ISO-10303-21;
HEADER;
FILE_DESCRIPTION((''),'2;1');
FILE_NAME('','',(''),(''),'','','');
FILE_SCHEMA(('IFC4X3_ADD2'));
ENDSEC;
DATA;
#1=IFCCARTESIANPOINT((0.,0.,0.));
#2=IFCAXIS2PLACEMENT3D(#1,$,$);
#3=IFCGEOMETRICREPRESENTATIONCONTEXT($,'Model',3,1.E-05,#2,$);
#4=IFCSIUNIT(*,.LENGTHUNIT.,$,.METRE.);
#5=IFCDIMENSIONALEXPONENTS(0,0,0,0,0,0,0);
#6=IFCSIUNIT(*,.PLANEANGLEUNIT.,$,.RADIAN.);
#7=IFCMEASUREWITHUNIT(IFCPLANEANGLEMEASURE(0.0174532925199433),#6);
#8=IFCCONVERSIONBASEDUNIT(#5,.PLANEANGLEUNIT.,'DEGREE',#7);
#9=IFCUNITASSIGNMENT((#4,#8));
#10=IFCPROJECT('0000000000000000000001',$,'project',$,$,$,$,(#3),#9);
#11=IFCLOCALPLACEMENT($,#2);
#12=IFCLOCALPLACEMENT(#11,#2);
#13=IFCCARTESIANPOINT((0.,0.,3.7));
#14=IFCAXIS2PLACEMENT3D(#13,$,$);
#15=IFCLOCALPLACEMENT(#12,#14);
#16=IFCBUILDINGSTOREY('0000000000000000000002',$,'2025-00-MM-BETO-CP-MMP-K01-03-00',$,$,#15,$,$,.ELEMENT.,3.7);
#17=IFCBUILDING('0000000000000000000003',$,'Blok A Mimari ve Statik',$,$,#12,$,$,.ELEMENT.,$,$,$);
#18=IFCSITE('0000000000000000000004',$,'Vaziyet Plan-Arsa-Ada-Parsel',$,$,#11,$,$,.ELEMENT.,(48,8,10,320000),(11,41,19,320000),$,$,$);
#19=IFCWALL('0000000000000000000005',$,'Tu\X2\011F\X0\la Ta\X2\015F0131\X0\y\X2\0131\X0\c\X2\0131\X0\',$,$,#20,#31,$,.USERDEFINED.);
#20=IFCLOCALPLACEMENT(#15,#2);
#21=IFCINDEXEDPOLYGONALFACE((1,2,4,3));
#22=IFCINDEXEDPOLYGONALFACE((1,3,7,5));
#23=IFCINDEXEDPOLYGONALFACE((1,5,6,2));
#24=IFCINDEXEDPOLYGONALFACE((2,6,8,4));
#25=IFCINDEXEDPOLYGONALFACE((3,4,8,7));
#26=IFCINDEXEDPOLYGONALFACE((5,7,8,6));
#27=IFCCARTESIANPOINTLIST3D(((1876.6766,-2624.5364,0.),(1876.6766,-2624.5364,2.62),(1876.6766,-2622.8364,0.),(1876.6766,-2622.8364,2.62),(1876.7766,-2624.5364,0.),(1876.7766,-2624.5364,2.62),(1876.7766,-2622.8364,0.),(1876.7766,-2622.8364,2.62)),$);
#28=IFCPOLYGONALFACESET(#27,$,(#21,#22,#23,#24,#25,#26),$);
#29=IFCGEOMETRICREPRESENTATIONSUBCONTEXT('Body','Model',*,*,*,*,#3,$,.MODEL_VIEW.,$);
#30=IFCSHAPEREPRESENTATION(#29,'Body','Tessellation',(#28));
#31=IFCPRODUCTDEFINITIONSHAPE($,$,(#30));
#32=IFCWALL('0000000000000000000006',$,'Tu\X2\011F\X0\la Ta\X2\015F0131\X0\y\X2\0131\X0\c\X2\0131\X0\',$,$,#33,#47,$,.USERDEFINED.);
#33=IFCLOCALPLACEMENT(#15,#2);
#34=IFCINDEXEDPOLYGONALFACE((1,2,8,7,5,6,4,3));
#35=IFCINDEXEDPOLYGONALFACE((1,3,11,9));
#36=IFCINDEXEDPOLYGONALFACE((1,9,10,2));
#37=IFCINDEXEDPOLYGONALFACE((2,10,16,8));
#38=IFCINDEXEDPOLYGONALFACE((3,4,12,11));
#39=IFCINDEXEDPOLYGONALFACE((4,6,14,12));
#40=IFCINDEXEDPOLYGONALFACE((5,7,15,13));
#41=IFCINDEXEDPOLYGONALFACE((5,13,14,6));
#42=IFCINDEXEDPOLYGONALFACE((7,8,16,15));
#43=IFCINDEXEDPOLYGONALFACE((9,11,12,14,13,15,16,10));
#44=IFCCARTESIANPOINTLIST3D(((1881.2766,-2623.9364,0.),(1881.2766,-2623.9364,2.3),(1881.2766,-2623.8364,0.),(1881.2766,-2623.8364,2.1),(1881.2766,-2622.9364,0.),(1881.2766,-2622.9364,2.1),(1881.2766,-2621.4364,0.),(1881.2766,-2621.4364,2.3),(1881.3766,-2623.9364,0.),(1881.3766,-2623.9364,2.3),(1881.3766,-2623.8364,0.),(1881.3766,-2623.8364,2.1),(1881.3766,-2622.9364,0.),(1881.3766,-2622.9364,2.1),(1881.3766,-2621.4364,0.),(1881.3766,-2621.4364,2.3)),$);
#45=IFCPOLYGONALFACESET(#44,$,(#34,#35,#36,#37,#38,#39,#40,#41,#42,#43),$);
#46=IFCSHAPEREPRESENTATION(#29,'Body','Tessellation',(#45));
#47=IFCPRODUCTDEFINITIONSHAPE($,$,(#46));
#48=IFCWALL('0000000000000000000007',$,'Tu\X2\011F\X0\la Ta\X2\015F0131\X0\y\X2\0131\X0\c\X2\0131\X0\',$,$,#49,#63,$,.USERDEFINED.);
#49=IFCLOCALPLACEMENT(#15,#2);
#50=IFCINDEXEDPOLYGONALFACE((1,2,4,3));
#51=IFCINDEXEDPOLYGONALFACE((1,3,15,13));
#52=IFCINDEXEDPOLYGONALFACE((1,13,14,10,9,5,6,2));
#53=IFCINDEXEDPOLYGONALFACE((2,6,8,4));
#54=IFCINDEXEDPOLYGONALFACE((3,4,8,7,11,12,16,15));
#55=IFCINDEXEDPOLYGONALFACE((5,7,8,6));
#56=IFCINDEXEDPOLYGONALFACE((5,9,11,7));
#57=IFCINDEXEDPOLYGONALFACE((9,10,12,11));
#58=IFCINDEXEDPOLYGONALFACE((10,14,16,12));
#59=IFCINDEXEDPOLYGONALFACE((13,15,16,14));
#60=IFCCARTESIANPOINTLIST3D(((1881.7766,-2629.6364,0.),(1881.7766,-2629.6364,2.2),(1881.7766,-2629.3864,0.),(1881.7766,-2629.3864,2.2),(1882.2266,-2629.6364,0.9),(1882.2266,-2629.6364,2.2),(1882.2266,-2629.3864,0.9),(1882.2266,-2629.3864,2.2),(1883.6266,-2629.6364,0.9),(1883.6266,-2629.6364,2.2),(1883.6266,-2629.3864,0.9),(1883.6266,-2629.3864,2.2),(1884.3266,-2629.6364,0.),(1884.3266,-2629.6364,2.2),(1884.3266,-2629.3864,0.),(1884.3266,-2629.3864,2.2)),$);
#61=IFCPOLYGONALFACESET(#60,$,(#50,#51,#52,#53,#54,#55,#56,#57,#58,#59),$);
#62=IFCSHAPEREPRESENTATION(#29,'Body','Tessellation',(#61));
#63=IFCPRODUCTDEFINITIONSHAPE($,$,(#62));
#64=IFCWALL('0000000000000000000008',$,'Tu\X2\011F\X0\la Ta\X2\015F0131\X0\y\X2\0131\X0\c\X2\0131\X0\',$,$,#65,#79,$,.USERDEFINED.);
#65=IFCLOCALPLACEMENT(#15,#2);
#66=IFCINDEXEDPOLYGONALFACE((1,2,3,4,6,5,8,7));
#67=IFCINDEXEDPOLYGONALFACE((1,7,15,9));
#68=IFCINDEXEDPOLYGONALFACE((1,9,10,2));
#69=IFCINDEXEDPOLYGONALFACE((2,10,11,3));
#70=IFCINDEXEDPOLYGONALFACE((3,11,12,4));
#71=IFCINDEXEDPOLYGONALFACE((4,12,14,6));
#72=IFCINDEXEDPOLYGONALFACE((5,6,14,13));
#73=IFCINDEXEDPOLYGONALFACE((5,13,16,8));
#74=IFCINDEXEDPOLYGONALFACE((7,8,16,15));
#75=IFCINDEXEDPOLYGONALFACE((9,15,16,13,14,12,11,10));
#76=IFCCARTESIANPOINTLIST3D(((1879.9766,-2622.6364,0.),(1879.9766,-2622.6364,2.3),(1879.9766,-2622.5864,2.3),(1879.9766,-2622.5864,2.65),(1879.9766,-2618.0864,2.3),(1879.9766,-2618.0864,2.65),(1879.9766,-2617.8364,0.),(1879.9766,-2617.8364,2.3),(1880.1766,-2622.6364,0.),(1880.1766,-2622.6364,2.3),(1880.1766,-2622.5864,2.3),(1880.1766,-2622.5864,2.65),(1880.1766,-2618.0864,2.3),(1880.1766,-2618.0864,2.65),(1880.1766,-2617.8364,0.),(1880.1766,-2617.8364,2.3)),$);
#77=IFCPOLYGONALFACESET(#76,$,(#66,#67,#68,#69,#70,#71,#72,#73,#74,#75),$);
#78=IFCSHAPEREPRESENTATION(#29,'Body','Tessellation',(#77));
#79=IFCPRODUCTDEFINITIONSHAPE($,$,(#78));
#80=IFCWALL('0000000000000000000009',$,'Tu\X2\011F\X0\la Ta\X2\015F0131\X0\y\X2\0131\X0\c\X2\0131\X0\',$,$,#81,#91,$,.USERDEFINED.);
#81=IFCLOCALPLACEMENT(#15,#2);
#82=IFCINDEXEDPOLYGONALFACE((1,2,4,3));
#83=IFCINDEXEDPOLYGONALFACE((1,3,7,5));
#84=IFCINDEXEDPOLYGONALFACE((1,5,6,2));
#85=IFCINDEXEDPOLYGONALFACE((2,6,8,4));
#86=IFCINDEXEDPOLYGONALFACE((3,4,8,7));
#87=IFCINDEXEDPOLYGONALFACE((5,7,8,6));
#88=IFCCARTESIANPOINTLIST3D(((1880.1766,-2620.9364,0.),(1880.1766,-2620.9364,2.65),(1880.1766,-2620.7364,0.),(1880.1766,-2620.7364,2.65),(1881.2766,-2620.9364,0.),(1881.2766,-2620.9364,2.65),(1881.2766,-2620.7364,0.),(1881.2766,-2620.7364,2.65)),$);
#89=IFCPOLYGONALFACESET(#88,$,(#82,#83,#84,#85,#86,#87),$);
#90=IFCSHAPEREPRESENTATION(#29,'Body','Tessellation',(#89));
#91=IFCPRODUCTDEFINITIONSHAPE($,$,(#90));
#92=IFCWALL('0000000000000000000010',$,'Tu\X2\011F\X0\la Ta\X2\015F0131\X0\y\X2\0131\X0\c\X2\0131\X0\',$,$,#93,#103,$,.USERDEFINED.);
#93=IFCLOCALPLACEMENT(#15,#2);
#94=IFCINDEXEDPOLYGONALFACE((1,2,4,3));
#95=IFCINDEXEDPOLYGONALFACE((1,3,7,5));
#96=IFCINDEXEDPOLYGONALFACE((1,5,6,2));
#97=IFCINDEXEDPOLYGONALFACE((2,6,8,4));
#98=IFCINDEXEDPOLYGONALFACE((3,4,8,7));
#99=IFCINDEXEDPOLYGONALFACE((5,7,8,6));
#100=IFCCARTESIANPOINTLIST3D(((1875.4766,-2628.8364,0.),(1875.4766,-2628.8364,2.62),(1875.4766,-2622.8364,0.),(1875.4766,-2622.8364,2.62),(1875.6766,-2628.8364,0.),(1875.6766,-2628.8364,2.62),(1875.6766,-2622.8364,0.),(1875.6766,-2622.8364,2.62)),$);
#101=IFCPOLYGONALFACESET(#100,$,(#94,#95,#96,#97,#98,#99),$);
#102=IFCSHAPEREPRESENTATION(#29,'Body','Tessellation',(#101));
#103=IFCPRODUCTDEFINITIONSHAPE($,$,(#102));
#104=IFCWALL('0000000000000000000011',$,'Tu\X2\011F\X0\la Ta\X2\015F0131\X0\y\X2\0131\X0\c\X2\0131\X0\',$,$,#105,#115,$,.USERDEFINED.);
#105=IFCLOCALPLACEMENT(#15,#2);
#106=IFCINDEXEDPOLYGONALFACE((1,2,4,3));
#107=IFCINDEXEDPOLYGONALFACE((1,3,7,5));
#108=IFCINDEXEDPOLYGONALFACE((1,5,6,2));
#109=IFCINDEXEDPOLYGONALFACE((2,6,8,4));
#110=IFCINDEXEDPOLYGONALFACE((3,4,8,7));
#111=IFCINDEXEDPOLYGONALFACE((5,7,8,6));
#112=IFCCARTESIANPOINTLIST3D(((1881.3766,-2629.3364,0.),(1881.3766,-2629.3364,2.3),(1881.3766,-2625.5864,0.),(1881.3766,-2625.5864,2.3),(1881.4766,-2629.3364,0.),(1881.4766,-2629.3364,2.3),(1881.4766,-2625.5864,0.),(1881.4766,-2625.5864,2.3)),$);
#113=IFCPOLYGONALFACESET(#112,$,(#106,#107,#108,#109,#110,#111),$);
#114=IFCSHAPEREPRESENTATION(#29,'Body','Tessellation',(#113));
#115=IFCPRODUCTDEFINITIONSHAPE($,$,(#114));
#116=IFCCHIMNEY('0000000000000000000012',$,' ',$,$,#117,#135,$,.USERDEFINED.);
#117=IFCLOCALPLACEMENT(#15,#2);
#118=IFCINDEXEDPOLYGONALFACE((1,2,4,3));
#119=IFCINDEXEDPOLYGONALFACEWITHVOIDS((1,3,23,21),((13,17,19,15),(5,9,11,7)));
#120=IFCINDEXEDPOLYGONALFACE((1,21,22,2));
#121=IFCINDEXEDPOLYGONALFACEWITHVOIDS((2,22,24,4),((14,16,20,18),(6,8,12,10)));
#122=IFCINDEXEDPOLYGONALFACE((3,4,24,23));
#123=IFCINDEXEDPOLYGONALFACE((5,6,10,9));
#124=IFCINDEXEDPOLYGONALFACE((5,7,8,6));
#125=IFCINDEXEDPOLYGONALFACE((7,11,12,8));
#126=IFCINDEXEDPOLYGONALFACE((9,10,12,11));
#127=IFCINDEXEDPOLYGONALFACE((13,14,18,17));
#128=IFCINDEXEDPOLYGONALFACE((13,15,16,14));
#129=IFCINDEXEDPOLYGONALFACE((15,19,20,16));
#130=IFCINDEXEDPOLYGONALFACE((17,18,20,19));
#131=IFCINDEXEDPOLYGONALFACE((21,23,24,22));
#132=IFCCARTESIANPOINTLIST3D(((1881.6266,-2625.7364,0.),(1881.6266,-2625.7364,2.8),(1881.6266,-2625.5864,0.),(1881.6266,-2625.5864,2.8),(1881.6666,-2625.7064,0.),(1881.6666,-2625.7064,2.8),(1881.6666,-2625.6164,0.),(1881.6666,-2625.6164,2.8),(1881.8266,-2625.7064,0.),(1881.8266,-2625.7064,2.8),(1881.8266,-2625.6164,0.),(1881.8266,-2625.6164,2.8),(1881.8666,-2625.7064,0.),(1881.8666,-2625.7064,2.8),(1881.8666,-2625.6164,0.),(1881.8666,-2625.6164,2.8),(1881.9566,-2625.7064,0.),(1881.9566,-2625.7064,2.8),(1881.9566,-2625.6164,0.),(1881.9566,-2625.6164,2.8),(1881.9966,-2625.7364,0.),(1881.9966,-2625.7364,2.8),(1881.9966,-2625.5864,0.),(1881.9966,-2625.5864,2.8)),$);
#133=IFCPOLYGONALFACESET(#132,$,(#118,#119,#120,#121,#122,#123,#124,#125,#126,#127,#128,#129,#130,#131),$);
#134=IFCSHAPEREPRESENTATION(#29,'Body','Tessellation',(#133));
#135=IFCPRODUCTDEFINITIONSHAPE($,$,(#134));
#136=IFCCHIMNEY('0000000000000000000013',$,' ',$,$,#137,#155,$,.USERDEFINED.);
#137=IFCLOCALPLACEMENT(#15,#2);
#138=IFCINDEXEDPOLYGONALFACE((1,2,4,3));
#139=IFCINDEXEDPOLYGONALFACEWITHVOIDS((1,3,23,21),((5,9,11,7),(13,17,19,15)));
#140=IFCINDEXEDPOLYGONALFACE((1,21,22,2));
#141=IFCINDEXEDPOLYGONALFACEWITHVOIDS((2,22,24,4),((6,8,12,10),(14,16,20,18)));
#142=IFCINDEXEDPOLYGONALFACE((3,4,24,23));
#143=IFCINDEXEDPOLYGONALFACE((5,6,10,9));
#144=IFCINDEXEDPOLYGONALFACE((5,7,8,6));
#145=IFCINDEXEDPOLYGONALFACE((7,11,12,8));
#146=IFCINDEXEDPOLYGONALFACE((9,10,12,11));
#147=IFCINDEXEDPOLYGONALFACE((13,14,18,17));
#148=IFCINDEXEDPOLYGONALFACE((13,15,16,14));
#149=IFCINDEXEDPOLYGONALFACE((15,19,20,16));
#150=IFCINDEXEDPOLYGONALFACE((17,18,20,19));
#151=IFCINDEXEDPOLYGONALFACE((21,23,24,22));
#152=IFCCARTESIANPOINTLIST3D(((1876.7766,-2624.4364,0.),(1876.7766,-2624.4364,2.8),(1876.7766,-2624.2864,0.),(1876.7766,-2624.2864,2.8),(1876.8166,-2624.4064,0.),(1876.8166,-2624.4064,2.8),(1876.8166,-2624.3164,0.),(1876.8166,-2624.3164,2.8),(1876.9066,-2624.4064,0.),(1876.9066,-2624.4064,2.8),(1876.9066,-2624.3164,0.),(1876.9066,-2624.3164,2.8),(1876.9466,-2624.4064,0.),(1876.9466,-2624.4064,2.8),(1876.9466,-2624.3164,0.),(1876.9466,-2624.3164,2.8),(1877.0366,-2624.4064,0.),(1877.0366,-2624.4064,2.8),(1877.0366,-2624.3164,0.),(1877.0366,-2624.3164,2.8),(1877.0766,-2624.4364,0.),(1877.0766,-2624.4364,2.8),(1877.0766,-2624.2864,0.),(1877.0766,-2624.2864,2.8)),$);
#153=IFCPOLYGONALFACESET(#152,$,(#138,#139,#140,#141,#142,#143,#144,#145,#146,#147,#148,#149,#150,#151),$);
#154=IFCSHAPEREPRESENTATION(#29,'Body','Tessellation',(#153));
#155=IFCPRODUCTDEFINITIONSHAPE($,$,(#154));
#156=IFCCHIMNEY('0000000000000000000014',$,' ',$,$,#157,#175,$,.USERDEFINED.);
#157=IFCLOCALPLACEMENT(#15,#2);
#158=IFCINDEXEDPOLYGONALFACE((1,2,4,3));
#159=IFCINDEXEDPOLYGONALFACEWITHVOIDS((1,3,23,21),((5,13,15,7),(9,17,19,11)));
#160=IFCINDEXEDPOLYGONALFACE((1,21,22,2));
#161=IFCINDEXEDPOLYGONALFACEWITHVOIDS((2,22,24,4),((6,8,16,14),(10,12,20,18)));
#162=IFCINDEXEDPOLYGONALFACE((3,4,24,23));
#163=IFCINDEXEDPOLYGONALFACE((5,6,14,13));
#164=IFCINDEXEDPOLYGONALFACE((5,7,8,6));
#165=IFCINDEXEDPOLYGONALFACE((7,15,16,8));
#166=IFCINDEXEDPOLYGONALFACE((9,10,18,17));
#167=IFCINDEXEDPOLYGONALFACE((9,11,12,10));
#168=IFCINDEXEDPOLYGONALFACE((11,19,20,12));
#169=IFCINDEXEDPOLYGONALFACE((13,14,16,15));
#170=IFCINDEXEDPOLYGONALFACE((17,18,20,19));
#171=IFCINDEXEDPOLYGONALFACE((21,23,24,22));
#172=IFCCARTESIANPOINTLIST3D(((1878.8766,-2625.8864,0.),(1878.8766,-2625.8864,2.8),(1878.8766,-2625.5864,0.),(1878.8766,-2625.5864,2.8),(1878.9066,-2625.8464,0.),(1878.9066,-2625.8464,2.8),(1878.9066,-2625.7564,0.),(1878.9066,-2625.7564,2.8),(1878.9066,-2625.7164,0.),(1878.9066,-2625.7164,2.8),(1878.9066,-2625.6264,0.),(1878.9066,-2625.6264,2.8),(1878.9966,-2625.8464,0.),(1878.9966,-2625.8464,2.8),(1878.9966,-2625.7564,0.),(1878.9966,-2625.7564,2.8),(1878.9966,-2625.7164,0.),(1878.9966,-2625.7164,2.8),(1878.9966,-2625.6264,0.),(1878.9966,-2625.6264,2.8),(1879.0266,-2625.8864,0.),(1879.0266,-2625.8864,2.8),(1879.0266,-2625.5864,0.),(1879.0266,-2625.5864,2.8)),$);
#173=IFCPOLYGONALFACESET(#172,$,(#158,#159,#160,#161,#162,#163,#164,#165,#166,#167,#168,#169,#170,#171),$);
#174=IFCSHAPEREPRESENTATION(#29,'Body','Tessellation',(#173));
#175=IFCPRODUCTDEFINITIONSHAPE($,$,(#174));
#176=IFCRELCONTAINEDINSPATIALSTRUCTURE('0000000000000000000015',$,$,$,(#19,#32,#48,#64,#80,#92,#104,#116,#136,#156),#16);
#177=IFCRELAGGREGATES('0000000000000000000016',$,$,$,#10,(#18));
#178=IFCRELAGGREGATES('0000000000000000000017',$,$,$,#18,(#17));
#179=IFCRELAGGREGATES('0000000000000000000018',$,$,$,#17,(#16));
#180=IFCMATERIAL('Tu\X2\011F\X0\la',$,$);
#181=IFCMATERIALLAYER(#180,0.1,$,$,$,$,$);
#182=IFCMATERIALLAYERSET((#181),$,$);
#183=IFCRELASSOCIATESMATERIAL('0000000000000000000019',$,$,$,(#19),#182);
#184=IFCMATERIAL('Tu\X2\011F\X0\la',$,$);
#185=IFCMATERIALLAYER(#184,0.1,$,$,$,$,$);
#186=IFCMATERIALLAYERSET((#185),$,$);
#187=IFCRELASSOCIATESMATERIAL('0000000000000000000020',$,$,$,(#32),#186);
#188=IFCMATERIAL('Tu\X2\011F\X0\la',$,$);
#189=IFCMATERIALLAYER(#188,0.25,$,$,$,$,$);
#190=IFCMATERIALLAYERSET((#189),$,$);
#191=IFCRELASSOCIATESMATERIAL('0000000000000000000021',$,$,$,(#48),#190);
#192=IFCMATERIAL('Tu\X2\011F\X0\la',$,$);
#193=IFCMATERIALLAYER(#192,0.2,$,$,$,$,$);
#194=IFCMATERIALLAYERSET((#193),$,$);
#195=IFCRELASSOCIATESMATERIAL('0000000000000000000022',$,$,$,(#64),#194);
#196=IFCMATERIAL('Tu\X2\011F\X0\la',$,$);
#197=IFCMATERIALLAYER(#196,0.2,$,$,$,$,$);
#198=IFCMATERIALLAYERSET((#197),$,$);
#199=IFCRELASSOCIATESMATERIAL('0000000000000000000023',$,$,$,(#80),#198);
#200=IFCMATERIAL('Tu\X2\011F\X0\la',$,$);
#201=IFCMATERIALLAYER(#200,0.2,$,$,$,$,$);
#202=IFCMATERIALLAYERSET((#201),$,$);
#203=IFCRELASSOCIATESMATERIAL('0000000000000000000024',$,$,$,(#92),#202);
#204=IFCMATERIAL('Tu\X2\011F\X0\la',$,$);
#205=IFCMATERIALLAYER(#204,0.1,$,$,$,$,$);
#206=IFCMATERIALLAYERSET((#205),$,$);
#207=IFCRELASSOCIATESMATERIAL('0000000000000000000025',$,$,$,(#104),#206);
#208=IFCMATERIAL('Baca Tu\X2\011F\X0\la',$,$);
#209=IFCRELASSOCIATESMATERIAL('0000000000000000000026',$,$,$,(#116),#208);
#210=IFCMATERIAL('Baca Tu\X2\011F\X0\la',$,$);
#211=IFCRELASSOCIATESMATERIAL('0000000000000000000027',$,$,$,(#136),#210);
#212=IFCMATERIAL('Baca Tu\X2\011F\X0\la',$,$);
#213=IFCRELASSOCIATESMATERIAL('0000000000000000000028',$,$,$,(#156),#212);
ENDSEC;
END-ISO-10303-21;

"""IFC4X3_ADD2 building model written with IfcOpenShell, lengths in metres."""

from ifc_helpers import new_model, entity, si_unit, converted_unit, frame, frame_2d, origin, origin_with_axes, place, context, subcontext, project, spatial, polyline, rectangle, outline, extrude, clip, bounded_halfspace, material, layer, layer_set, layer_usage, element, save


model = new_model("IFC4X3_ADD2")

# Units and contexts
model_context = context("Model", 3, precision=1e-05, world=origin())
body_context = subcontext(model_context, "Body", "Model", "MODEL_VIEW")
ifc_project = project(units=[si_unit("LENGTHUNIT", "METRE"), converted_unit("PLANEANGLEUNIT", "DEGREE", entity("IfcPlaneAngleMeasure", 0.0174532925199433), si_unit("PLANEANGLEUNIT", "RADIAN"), dimensions=[0, 0, 0, 0, 0, 0, 0])], contexts=[model_context])

# Site, building, storey
site_placement = place(None, origin())
site = spatial("IfcSite", under=ifc_project, at=site_placement, Name="Vaziyet Plan-Arsa-Ada-Parsel", CompositionType="ELEMENT", RefLatitude=(48, 8, 10, 320000), RefLongitude=(11, 41, 19, 320000))
building_placement = place(site_placement, origin())
building = spatial("IfcBuilding", under=site, at=building_placement, Name="Blok A Mimari ve Statik", CompositionType="ELEMENT")
storey_placement = place(building_placement, frame((0.0, 0.0, 3.7)))
storey = spatial("IfcBuildingStorey", under=building, at=storey_placement, Name="2025-00-MM-BETO-CP-MMP-K01-03-00", CompositionType="ELEMENT", Elevation=3.7)

# Wall
ifc_material_1 = material(Name="Tuğla")
ifc_layer_1 = layer(ifc_material_1, 0.1)
ifc_layer_set_1 = layer_set([ifc_layer_1])
ifc_layer_usage_1 = layer_usage(ifc_layer_set_1, "AXIS2", "POSITIVE", 0.0)
wall_1_placement = place(storey_placement, frame((1876.6766, -2622.8364, 0.0), z_axis=(0.0, 0.0, 1.0), x_axis=(0.0, -1.0, 0.0)))
element("IfcWall", 1, at=wall_1_placement, inside=storey, material=ifc_layer_usage_1, Name="Tuğla Taşıyıcı", PredefinedType="USERDEFINED", context=body_context, shape_type="SweptSolid", body=[
    extrude(rectangle(XDim=1.7, YDim=0.1, at=frame_2d((0.85, 0.05), x_axis=(1.0, 0.0))), origin_with_axes(), (0.0, 0.0, 1.0), 2.62),
])

# Walls, openings
ifc_material_2 = material(Name="Tuğla")
ifc_layer_2 = layer(ifc_material_2, 0.1)
ifc_layer_set_2 = layer_set([ifc_layer_2])
ifc_layer_usage_2 = layer_usage(ifc_layer_set_2, "AXIS2", "POSITIVE", 0.0)
wall_2_placement = place(storey_placement, frame((1881.2766, -2621.4364, 0.0), z_axis=(0.0, 0.0, 1.0), x_axis=(0.0, -1.0, 0.0)))
wall_2 = element("IfcWall", 2, at=wall_2_placement, inside=storey, material=ifc_layer_usage_2, Name="Tuğla Taşıyıcı", PredefinedType="USERDEFINED", context=body_context, shape_type="SweptSolid", body=[
    extrude(rectangle(XDim=2.5, YDim=0.1, at=frame_2d((1.25, 0.05), x_axis=(1.0, 0.0))), origin_with_axes(), (0.0, 0.0, 1.0), 2.3),
])
opening_1_placement = place(wall_2_placement, frame((2.4, 0.1, 0.0), z_axis=(0.0, -1.0, 0.0), x_axis=(0.0, 0.0, 1.0)))
element("IfcOpeningElement", 3, at=opening_1_placement, cuts=wall_2, PredefinedType="OPENING", context=body_context, shape_type="SweptSolid", body=[
    extrude(outline(polyline([(2.1, 0.9), (2.1, 0.0), (0.0, 0.0), (0.0, 0.9), (2.1, 0.9)])), origin_with_axes(), (0.0, 0.0, 1.0), 0.1),
])
ifc_material_3 = material(Name="Tuğla")
ifc_layer_3 = layer(ifc_material_3, 0.25)
ifc_layer_set_3 = layer_set([ifc_layer_3])
ifc_layer_usage_3 = layer_usage(ifc_layer_set_3, "AXIS2", "POSITIVE", 0.0)
wall_3_placement = place(storey_placement, frame((1881.7766, -2629.6364, 0.0), z_axis=(0.0, 0.0, 1.0), x_axis=(1.0, 0.0, 0.0)))
wall_3 = element("IfcWall", 4, at=wall_3_placement, inside=storey, material=ifc_layer_usage_3, Name="Tuğla Taşıyıcı", PredefinedType="USERDEFINED", context=body_context, shape_type="SweptSolid", body=[
    extrude(rectangle(XDim=2.55, YDim=0.25, at=frame_2d((1.275, 0.125), x_axis=(1.0, 0.0))), origin_with_axes(), (0.0, 0.0, 1.0), 2.2),
])
opening_2_placement = place(wall_3_placement, frame((0.45, 0.0, 0.9), z_axis=(0.0, 1.0, 0.0), x_axis=(0.0, 0.0, 1.0)))
element("IfcOpeningElement", 5, at=opening_2_placement, cuts=wall_3, PredefinedType="OPENING", context=body_context, shape_type="SweptSolid", body=[
    extrude(outline(polyline([(1.35, 1.4), (1.35, 0.0), (0.0, 0.0), (0.0, 1.4), (1.35, 1.4)])), origin_with_axes(), (0.0, 0.0, 1.0), 0.25),
])

# Walls
ifc_material_4 = material(Name="Tuğla")
ifc_layer_4 = layer(ifc_material_4, 0.2)
ifc_layer_set_4 = layer_set([ifc_layer_4])
ifc_layer_usage_4 = layer_usage(ifc_layer_set_4, "AXIS2", "POSITIVE", 0.0)
wall_4_placement = place(storey_placement, frame((1880.1766, -2622.6364, 0.0), z_axis=(0.0, 0.0, 1.0), x_axis=(0.0, 1.0, 0.0)))
element("IfcWall", 6, at=wall_4_placement, inside=storey, material=ifc_layer_usage_4, Name="Tuğla Taşıyıcı", PredefinedType="USERDEFINED", context=body_context, shape_type="Clipping", body=[
    clip(clip(extrude(rectangle(XDim=4.8, YDim=0.2, at=frame_2d((2.4, 0.1), x_axis=(1.0, 0.0))), origin_with_axes(), (0.0, 0.0, 1.0), 2.65), bounded_halfspace(frame((4.675, 0.1, 2.3), z_axis=(0.0, 0.0, -1.0), x_axis=(-1.0, 0.0, 0.0)), True, origin_with_axes(), polyline([(4.8, 0.2), (4.55, 0.2), (4.55, 0.0), (4.8, 0.0), (4.8, 0.2)]))), bounded_halfspace(frame((0.025, 0.1, 2.3), z_axis=(0.0, 0.0, -1.0), x_axis=(0.0, -1.0, 0.0)), True, origin_with_axes(), polyline([(0.0, 0.2), (0.0, 0.0), (0.05, 0.0), (0.05, 0.2), (0.0, 0.2)]))),
])
ifc_material_5 = material(Name="Tuğla")
ifc_layer_5 = layer(ifc_material_5, 0.2)
ifc_layer_set_5 = layer_set([ifc_layer_5])
ifc_layer_usage_5 = layer_usage(ifc_layer_set_5, "AXIS2", "POSITIVE", 0.0)
wall_5_placement = place(storey_placement, frame((1880.1766, -2620.9364, 0.0)))
element("IfcWall", 7, at=wall_5_placement, inside=storey, material=ifc_layer_usage_5, Name="Tuğla Taşıyıcı", PredefinedType="USERDEFINED", context=body_context, shape_type="SweptSolid", body=[
    extrude(rectangle(XDim=1.1, YDim=0.2, at=frame_2d((0.55, 0.1), x_axis=(1.0, 0.0))), origin_with_axes(), (0.0, 0.0, 1.0), 2.65),
])
ifc_material_6 = material(Name="Tuğla")
ifc_layer_6 = layer(ifc_material_6, 0.2)
ifc_layer_set_6 = layer_set([ifc_layer_6])
ifc_layer_usage_6 = layer_usage(ifc_layer_set_6, "AXIS2", "POSITIVE", 0.0)
wall_6_placement = place(storey_placement, frame((1875.4766, -2622.8364, 0.0), z_axis=(0.0, 0.0, 1.0), x_axis=(0.0, -1.0, 0.0)))
element("IfcWall", 8, at=wall_6_placement, inside=storey, material=ifc_layer_usage_6, Name="Tuğla Taşıyıcı", PredefinedType="USERDEFINED", context=body_context, shape_type="SweptSolid", body=[
    extrude(rectangle(XDim=6.0, YDim=0.2, at=frame_2d((3.0, 0.1), x_axis=(1.0, 0.0))), origin_with_axes(), (0.0, 0.0, 1.0), 2.62),
])
ifc_material_7 = material(Name="Tuğla")
ifc_layer_7 = layer(ifc_material_7, 0.1)
ifc_layer_set_7 = layer_set([ifc_layer_7])
ifc_layer_usage_7 = layer_usage(ifc_layer_set_7, "AXIS2", "POSITIVE", 0.0)
wall_7_placement = place(storey_placement, frame((1881.4766, -2629.3364, 0.0), z_axis=(0.0, 0.0, 1.0), x_axis=(0.0, 1.0, 0.0)))
element("IfcWall", 9, at=wall_7_placement, inside=storey, material=ifc_layer_usage_7, Name="Tuğla Taşıyıcı", PredefinedType="USERDEFINED", context=body_context, shape_type="SweptSolid", body=[
    extrude(rectangle(XDim=3.75, YDim=0.1, at=frame_2d((1.875, 0.05), x_axis=(1.0, 0.0))), origin_with_axes(), (0.0, 0.0, 1.0), 2.3),
])

# Chimneys
ifc_material_8 = material(Name="Baca Tuğla")
chimney_1_placement = place(storey_placement, frame((1881.6266, -2625.7364, 0.0)))
element("IfcChimney", 10, at=chimney_1_placement, inside=storey, material=ifc_material_8, Name=" ", PredefinedType="USERDEFINED", context=body_context, shape_type="SweptSolid", body=[
    extrude(outline(polyline([(0.0, 0.0), (0.37, 0.0), (0.37, 0.15), (0.0, 0.15), (0.0, 0.0)]), holes=[polyline([(0.04, 0.03), (0.04, 0.12), (0.2, 0.12), (0.2, 0.03), (0.04, 0.03)]), polyline([(0.24, 0.03), (0.24, 0.12), (0.33, 0.12), (0.33, 0.03), (0.24, 0.03)])]), origin_with_axes(), (0.0, 0.0, 1.0), 2.8),
])
ifc_material_9 = material(Name="Baca Tuğla")
chimney_2_placement = place(storey_placement, frame((1876.7766, -2624.4364, 0.0)))
element("IfcChimney", 11, at=chimney_2_placement, inside=storey, material=ifc_material_9, Name=" ", PredefinedType="USERDEFINED", context=body_context, shape_type="SweptSolid", body=[
    extrude(outline(polyline([(0.3, 0.15), (0.0, 0.15), (0.0, 0.0), (0.3, 0.0), (0.3, 0.15)]), holes=[polyline([(0.26, 0.12), (0.26, 0.03), (0.17, 0.03), (0.17, 0.12), (0.26, 0.12)]), polyline([(0.13, 0.12), (0.13, 0.03), (0.04, 0.03), (0.04, 0.12), (0.13, 0.12)])]), origin_with_axes(), (0.0, 0.0, 1.0), 2.8),
])
ifc_material_10 = material(Name="Baca Tuğla")
chimney_3_placement = place(storey_placement, frame((1878.8766, -2625.8864, 0.0)))
element("IfcChimney", 12, at=chimney_3_placement, inside=storey, material=ifc_material_10, Name=" ", PredefinedType="USERDEFINED", context=body_context, shape_type="SweptSolid", body=[
    extrude(outline(polyline([(0.15, 0.0), (0.15, 0.3), (0.0, 0.3), (0.0, 0.0), (0.15, 0.0)]), holes=[polyline([(0.12, 0.17), (0.03, 0.17), (0.03, 0.26), (0.12, 0.26), (0.12, 0.17)]), polyline([(0.12, 0.04), (0.03, 0.04), (0.03, 0.13), (0.12, 0.13), (0.12, 0.04)])]), origin_with_axes(), (0.0, 0.0, 1.0), 2.8),
])

save(model, "model.ifc")
